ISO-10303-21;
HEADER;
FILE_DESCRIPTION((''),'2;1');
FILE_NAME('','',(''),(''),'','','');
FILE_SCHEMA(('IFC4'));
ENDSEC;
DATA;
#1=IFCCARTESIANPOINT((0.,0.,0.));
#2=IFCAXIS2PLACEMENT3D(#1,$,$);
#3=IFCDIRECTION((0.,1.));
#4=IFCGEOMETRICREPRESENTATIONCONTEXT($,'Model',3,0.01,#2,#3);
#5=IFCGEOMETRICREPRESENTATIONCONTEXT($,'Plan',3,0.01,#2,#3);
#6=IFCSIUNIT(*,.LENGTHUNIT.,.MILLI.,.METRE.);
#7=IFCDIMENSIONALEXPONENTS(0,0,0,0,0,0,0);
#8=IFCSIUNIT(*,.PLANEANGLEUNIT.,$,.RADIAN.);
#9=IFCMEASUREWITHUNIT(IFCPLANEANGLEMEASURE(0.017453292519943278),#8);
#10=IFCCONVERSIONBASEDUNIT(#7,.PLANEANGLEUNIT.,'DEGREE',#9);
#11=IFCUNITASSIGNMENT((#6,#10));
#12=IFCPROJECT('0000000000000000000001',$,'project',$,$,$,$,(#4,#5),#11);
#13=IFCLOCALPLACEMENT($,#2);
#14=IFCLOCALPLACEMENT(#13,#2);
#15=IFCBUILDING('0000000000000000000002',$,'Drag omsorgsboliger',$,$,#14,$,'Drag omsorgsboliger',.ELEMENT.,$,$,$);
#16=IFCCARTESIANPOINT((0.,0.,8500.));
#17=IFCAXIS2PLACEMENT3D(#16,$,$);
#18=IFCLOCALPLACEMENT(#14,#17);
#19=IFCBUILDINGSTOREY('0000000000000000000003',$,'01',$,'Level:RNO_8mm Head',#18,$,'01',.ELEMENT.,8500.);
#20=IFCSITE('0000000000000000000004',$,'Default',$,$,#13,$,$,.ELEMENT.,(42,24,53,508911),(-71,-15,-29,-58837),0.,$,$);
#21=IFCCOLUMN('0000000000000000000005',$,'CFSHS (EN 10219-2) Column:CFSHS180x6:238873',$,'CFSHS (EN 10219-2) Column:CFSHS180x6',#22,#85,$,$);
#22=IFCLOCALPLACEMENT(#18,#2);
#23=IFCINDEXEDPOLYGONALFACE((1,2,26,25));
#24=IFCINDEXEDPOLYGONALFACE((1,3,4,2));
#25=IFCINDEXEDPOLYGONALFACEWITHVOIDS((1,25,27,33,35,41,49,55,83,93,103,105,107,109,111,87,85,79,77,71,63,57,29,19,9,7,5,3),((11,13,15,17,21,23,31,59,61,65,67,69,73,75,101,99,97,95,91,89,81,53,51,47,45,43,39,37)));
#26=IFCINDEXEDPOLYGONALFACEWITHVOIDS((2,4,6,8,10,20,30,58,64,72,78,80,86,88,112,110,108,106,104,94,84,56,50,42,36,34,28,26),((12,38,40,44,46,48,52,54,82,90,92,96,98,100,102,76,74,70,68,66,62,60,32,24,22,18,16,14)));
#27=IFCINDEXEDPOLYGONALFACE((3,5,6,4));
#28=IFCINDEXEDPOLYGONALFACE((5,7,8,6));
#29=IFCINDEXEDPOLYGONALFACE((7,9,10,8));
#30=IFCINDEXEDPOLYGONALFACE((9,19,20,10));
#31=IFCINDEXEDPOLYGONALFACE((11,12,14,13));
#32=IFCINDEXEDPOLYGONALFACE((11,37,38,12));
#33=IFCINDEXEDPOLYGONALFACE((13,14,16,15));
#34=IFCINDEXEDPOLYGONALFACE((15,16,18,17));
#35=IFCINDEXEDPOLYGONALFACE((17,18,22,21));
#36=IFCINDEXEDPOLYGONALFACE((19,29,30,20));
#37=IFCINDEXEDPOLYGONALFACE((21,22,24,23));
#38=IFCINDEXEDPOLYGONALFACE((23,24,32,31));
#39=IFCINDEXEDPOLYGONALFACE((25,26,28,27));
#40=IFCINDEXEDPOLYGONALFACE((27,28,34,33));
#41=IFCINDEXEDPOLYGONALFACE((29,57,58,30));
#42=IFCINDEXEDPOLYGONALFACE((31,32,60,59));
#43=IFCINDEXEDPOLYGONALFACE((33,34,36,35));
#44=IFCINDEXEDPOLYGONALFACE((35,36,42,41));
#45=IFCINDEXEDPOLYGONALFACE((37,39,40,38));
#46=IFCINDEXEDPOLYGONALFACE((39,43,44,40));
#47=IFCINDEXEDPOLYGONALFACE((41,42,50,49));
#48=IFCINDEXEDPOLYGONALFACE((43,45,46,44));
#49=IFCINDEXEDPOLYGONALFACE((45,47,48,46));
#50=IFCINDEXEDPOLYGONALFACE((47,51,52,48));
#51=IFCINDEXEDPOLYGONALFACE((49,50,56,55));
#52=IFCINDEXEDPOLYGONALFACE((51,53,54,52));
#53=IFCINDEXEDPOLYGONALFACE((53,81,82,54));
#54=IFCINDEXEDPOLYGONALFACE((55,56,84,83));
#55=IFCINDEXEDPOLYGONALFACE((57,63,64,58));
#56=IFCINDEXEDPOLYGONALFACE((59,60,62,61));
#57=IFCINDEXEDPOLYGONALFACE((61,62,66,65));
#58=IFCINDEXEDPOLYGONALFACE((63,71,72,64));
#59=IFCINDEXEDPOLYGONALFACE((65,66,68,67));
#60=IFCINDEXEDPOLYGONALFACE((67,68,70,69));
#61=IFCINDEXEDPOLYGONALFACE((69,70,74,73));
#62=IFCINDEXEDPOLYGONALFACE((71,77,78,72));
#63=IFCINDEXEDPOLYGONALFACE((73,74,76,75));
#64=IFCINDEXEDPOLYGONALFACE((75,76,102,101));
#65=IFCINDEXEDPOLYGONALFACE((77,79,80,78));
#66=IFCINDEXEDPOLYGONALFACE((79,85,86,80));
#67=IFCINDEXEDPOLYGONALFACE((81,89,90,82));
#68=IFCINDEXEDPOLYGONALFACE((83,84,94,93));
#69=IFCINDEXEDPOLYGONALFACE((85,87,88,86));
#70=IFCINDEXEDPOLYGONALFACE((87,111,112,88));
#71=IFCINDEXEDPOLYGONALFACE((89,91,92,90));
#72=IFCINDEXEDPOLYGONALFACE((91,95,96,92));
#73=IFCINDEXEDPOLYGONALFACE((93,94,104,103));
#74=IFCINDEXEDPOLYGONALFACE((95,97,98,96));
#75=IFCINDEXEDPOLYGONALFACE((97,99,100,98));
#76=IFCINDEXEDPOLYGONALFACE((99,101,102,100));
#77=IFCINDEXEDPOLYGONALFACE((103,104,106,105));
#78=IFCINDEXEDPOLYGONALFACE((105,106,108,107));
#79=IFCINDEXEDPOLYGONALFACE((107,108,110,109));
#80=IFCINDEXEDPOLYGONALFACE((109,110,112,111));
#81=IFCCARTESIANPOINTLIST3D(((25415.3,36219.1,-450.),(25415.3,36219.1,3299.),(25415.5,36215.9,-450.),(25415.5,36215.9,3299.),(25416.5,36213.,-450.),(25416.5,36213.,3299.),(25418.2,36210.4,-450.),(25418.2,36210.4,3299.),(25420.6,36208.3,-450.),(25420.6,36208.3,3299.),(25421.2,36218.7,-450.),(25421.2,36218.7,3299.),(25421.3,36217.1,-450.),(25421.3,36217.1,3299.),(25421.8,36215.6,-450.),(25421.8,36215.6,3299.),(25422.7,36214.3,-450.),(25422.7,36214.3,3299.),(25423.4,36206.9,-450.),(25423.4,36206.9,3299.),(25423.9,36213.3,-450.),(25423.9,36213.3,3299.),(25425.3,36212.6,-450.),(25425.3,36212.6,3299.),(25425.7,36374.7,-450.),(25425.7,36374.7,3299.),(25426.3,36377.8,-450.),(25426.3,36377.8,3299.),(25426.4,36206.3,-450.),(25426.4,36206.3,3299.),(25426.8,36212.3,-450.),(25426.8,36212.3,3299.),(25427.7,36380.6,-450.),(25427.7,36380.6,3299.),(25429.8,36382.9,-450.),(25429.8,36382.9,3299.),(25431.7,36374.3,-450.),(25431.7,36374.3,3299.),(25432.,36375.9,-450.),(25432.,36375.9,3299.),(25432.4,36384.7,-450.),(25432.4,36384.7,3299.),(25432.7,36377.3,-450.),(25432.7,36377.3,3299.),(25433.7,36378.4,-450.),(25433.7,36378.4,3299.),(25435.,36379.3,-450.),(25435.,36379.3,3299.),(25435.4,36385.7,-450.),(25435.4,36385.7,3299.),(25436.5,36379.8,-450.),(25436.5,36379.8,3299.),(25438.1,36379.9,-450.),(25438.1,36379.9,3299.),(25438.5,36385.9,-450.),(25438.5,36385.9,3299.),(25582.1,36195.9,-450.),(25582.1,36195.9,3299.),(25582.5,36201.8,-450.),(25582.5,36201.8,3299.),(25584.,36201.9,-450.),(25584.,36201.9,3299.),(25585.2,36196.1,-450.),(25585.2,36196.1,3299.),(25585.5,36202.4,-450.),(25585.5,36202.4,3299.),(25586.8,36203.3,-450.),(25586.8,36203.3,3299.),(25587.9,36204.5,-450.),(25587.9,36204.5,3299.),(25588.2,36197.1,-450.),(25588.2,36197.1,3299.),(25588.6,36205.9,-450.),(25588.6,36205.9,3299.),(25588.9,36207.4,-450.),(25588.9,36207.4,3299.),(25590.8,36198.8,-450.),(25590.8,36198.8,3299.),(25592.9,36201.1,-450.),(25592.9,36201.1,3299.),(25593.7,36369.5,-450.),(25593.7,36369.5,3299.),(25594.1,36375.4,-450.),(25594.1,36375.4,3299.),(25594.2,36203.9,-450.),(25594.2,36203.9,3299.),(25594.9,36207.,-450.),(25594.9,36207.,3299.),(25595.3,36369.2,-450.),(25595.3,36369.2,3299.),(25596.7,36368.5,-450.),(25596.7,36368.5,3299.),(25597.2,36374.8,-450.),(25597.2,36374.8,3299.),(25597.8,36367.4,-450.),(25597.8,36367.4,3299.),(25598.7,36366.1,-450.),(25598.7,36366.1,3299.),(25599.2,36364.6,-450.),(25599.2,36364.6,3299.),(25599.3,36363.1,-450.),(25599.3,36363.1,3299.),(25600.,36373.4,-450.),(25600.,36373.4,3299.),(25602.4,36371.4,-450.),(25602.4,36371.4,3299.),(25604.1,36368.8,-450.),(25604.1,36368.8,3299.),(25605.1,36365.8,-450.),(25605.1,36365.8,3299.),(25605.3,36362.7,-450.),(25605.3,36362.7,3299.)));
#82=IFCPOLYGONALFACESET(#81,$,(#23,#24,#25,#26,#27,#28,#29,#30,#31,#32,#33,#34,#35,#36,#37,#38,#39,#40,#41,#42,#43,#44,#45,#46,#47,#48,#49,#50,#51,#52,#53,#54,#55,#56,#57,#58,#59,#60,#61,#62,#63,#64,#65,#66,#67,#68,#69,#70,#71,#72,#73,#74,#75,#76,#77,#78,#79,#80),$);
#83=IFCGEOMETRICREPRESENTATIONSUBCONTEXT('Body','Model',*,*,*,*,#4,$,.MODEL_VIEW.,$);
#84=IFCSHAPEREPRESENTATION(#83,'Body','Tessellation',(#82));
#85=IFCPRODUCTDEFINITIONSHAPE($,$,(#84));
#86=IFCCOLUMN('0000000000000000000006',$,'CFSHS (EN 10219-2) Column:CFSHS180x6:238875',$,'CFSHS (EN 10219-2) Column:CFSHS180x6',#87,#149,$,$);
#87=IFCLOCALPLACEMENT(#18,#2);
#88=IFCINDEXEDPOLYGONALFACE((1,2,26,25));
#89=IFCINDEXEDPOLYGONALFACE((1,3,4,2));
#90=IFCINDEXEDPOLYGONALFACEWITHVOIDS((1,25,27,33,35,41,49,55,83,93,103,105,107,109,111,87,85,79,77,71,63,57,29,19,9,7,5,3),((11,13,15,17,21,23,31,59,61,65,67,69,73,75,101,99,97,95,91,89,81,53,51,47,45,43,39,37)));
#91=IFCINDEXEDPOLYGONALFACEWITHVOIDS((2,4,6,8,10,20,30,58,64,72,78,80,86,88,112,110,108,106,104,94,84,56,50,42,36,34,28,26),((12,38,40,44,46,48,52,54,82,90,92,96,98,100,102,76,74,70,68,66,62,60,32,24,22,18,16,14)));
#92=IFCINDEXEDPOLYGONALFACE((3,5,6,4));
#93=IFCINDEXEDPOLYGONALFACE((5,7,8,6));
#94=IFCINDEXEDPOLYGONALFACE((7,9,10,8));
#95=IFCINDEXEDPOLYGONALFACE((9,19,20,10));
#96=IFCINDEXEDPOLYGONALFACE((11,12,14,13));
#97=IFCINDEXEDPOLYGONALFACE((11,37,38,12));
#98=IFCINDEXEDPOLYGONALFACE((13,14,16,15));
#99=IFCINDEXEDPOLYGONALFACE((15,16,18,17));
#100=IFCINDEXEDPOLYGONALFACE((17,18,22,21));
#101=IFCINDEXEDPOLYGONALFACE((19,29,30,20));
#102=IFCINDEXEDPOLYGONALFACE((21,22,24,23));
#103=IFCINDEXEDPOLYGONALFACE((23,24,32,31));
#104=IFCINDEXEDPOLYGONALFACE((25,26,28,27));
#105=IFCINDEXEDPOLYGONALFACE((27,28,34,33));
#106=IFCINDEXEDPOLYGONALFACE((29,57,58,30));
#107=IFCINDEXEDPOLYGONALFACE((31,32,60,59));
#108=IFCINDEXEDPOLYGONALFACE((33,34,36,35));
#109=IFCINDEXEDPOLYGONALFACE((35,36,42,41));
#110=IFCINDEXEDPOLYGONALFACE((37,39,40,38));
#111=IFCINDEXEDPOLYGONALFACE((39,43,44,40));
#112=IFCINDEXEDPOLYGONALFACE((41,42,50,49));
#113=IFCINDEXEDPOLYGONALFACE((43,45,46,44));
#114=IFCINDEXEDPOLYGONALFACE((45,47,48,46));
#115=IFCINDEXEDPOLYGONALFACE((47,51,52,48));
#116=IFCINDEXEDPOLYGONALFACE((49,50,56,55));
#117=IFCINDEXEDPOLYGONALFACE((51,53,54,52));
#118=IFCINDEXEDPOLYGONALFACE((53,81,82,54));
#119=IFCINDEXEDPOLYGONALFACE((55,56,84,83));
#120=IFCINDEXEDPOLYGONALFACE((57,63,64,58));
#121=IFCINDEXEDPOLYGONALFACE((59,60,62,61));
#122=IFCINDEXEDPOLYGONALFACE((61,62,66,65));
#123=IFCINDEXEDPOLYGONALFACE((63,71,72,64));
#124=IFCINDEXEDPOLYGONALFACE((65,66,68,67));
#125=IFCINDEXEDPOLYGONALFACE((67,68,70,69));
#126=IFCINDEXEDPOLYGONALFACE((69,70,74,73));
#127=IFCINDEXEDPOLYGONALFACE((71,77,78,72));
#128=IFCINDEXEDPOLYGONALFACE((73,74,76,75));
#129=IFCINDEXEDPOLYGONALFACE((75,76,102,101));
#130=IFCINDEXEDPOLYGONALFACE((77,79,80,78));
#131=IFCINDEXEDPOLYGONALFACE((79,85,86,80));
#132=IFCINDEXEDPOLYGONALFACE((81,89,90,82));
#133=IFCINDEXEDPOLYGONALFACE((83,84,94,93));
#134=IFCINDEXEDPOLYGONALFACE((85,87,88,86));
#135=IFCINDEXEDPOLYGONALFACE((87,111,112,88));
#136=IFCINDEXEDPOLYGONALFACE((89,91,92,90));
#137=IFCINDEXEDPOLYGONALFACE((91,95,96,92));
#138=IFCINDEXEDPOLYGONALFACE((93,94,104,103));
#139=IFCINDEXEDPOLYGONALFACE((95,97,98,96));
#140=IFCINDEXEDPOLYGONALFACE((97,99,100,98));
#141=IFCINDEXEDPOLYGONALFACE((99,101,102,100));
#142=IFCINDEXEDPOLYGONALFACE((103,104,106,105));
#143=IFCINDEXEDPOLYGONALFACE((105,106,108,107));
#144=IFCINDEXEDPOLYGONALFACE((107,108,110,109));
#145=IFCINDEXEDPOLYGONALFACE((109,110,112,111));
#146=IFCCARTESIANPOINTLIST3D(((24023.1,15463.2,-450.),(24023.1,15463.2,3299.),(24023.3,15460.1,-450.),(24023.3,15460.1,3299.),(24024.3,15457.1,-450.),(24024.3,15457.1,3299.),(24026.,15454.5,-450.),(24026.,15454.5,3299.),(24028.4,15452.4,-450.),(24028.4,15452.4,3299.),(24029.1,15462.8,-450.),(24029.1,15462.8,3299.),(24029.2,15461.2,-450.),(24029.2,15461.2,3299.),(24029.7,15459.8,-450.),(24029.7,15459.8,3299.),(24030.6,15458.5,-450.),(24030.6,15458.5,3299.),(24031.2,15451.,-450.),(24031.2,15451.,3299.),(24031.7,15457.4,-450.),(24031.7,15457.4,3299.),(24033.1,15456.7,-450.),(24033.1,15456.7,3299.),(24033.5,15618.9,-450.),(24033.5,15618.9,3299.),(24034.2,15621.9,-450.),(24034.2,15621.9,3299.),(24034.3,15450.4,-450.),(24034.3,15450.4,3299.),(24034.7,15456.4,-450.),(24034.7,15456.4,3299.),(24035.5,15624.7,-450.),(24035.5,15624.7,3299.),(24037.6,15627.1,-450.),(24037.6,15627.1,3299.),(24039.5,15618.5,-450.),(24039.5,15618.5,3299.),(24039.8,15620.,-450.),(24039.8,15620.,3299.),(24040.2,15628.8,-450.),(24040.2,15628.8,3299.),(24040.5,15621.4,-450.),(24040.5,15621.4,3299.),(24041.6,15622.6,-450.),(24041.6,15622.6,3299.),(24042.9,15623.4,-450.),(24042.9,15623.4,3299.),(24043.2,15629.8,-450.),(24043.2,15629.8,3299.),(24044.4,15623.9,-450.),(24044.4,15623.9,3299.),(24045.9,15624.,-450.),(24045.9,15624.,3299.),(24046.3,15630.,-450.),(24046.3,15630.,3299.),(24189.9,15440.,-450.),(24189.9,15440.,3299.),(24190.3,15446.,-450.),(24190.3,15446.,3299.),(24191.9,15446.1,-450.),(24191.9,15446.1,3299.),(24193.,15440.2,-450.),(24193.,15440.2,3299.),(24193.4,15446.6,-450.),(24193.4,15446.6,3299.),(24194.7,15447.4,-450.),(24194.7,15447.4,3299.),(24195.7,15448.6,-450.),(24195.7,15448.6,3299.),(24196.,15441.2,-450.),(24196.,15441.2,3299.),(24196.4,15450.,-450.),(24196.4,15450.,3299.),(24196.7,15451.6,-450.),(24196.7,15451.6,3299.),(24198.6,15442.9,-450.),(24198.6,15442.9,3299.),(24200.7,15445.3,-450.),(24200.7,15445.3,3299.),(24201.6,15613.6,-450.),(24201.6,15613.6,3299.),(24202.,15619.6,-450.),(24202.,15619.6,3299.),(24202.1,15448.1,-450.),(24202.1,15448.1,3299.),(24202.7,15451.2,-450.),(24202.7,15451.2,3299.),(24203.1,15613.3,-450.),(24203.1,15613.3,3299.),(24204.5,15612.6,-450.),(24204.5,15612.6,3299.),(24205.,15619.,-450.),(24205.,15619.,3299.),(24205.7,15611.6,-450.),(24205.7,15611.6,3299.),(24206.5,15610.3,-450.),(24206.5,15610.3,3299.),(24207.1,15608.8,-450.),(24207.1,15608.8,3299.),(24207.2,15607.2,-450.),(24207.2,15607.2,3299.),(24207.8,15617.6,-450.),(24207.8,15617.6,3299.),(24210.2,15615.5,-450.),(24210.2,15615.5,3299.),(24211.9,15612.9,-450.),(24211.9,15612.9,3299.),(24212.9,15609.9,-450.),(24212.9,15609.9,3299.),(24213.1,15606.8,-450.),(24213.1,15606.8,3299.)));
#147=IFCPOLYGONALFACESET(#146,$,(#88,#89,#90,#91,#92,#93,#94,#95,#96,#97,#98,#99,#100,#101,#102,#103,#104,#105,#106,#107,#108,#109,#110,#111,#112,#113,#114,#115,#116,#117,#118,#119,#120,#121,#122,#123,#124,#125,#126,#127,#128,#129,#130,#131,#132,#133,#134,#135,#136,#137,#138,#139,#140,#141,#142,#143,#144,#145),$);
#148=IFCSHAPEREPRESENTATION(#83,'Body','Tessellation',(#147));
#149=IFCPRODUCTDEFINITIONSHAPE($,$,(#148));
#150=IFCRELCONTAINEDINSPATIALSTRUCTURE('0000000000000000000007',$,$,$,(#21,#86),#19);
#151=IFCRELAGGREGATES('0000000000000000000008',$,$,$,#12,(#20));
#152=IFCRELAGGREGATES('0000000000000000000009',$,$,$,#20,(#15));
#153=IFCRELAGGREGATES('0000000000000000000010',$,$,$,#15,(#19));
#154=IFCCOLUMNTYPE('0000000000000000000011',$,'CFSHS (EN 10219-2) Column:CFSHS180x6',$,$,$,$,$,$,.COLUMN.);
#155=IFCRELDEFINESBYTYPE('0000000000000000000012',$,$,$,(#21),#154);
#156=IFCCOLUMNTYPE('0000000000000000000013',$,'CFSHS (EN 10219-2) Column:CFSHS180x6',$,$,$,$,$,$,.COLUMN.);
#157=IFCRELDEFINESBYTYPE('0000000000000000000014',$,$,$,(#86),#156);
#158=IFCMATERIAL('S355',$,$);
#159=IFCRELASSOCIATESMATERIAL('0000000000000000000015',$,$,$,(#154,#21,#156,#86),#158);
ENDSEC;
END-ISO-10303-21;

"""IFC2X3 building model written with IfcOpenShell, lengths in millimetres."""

from ifc_helpers import new_model, entity, si_unit, converted_unit, direction, frame, frame_2d, origin, place, context, subcontext, project, spatial, polyline, circle_curve, parameter, trimmed, segment, composite_curve, outline, extrude, source, transform, mapped, material, type_object, type_shapes, element, save


model = new_model("IFC2X3")

# Units and contexts
model_context = context("Model", 3, precision=0.01, world=origin(), true_north=direction((0.0, 1.0)))
plan_context = context("Plan", 3, precision=0.01, world=origin(), true_north=direction((0.0, 1.0)))
body_context = subcontext(model_context, "Body", "Model", "MODEL_VIEW")
ifc_project = project(units=[si_unit("LENGTHUNIT", "METRE", prefix="MILLI"), converted_unit("PLANEANGLEUNIT", "DEGREE", entity("IfcPlaneAngleMeasure", 0.017453292519943278), si_unit("PLANEANGLEUNIT", "RADIAN"), dimensions=[0, 0, 0, 0, 0, 0, 0])], contexts=[model_context, plan_context])

# Site, building, storey
site_placement = place(None, origin())
site = spatial("IfcSite", under=ifc_project, at=site_placement, Name="Default", CompositionType="ELEMENT", RefLatitude=(42, 24, 53, 508911), RefLongitude=(-71, -15, -29, -58837), RefElevation=0.0)
building_placement = place(site_placement, origin())
building = spatial("IfcBuilding", under=site, at=building_placement, Name="Drag omsorgsboliger", LongName="Drag omsorgsboliger", CompositionType="ELEMENT")
storey_placement = place(building_placement, frame((0.0, 0.0, 8500.0)))
storey = spatial("IfcBuildingStorey", under=building, at=storey_placement, Name="01", ObjectType="Level:RNO_8mm Head", LongName="01", CompositionType="ELEMENT", Elevation=8500.0)

# Columns
ifc_material = material(Name="S355")
column_type_1 = type_object("IfcColumnType", Name="CFSHS (EN 10219-2) Column:CFSHS180x6", PredefinedType="COLUMN", material=ifc_material)
shared_shape_1 = source(origin(), body_context, "Body", "SweptSolid", [
    extrude(outline(composite_curve([segment(polyline([(-78.0, -90.0), (78.0, -90.0)]), True, "CONTINUOUS"), segment(trimmed(circle_curve(frame_2d((78.0, -78.0), x_axis=(-1.0, 0.0)), 12.0), [parameter(90.0)], [parameter(180.0)], True, "PARAMETER"), True, "CONTINUOUS"), segment(polyline([(90.0, -78.0), (90.0, 78.0)]), True, "CONTINUOUS"), segment(trimmed(circle_curve(frame_2d((78.0, 78.0), x_axis=(-1.0, 0.0)), 12.0), [parameter(180.0)], [parameter(270.0)], True, "PARAMETER"), True, "CONTINUOUS"), segment(polyline([(78.0, 90.0), (-78.0, 90.0)]), True, "CONTINUOUS"), segment(trimmed(circle_curve(frame_2d((-78.0, 78.0), x_axis=(-1.0, 0.0)), 12.0), [parameter(270.0)], [parameter(360.0)], True, "PARAMETER"), True, "CONTINUOUS"), segment(polyline([(-90.0, 78.0), (-90.0, -78.0)]), True, "CONTINUOUS"), segment(trimmed(circle_curve(frame_2d((-78.0, -78.0), x_axis=(-1.0, 0.0)), 12.0), [parameter(360.0)], [parameter(90.0)], True, "PARAMETER"), True, "CONTINUOUS")], self_intersect=False), holes=[composite_curve([segment(trimmed(circle_curve(frame_2d((-78.0, -78.0), x_axis=(-1.0, 0.0)), 6.0), [parameter(360.0)], [parameter(90.0)], True, "PARAMETER"), False, "CONTINUOUS"), segment(polyline([(-84.0, -78.0), (-84.0, 78.0)]), True, "CONTINUOUS"), segment(trimmed(circle_curve(frame_2d((-78.0, 78.0), x_axis=(-1.0, 0.0)), 6.0), [parameter(270.0)], [parameter(360.0)], True, "PARAMETER"), False, "CONTINUOUS"), segment(polyline([(-78.0, 84.0), (78.0, 84.0)]), True, "CONTINUOUS"), segment(trimmed(circle_curve(frame_2d((78.0, 78.0), x_axis=(-1.0, 0.0)), 6.0), [parameter(180.0)], [parameter(270.0)], True, "PARAMETER"), False, "CONTINUOUS"), segment(polyline([(84.0, 78.0), (84.0, -78.0)]), True, "CONTINUOUS"), segment(trimmed(circle_curve(frame_2d((78.0, -78.0), x_axis=(-1.0, 0.0)), 6.0), [parameter(90.0)], [parameter(180.0)], True, "PARAMETER"), False, "CONTINUOUS"), segment(polyline([(78.0, -84.0), (-78.0, -84.0)]), True, "CONTINUOUS")], self_intersect=False)]), frame((25510.3, 36290.9, 8050.0), z_axis=(0.0, 0.0, 1.0), x_axis=(-0.997758, 0.066923, 0.0)), (0.0, 0.0, 1.0), 3749.0),
])
type_shapes(column_type_1, [shared_shape_1])
column_1_placement = place(storey_placement, frame((0.0, 0.0, -8500.0)))
element("IfcColumn", 1, at=column_1_placement, inside=storey, type_object=column_type_1, material=ifc_material, Name="CFSHS (EN 10219-2) Column:CFSHS180x6:238873", ObjectType="CFSHS (EN 10219-2) Column:CFSHS180x6", context=body_context, shape_type="MappedRepresentation", body=[
    mapped(shared_shape_1, transform((0.0, 0.0, 0.0), scale=1.0)),
])
column_type_2 = type_object("IfcColumnType", Name="CFSHS (EN 10219-2) Column:CFSHS180x6", PredefinedType="COLUMN", material=ifc_material)
shared_shape_2 = source(origin(), body_context, "Body", "SweptSolid", [
    extrude(outline(composite_curve([segment(polyline([(-78.0, -90.0), (78.0, -90.0)]), True, "CONTINUOUS"), segment(trimmed(circle_curve(frame_2d((78.0, -78.0), x_axis=(-1.0, 0.0)), 12.0), [parameter(90.0)], [parameter(180.0)], True, "PARAMETER"), True, "CONTINUOUS"), segment(polyline([(90.0, -78.0), (90.0, 78.0)]), True, "CONTINUOUS"), segment(trimmed(circle_curve(frame_2d((78.0, 78.0), x_axis=(-1.0, 0.0)), 12.0), [parameter(180.0)], [parameter(270.0)], True, "PARAMETER"), True, "CONTINUOUS"), segment(polyline([(78.0, 90.0), (-78.0, 90.0)]), True, "CONTINUOUS"), segment(trimmed(circle_curve(frame_2d((-78.0, 78.0), x_axis=(-1.0, 0.0)), 12.0), [parameter(270.0)], [parameter(360.0)], True, "PARAMETER"), True, "CONTINUOUS"), segment(polyline([(-90.0, 78.0), (-90.0, -78.0)]), True, "CONTINUOUS"), segment(trimmed(circle_curve(frame_2d((-78.0, -78.0), x_axis=(-1.0, 0.0)), 12.0), [parameter(360.0)], [parameter(90.0)], True, "PARAMETER"), True, "CONTINUOUS")], self_intersect=False), holes=[composite_curve([segment(trimmed(circle_curve(frame_2d((-78.0, -78.0), x_axis=(-1.0, 0.0)), 6.0), [parameter(360.0)], [parameter(90.0)], True, "PARAMETER"), False, "CONTINUOUS"), segment(polyline([(-84.0, -78.0), (-84.0, 78.0)]), True, "CONTINUOUS"), segment(trimmed(circle_curve(frame_2d((-78.0, 78.0), x_axis=(-1.0, 0.0)), 6.0), [parameter(270.0)], [parameter(360.0)], True, "PARAMETER"), False, "CONTINUOUS"), segment(polyline([(-78.0, 84.0), (78.0, 84.0)]), True, "CONTINUOUS"), segment(trimmed(circle_curve(frame_2d((78.0, 78.0), x_axis=(-1.0, 0.0)), 6.0), [parameter(180.0)], [parameter(270.0)], True, "PARAMETER"), False, "CONTINUOUS"), segment(polyline([(84.0, 78.0), (84.0, -78.0)]), True, "CONTINUOUS"), segment(trimmed(circle_curve(frame_2d((78.0, -78.0), x_axis=(-1.0, 0.0)), 6.0), [parameter(90.0)], [parameter(180.0)], True, "PARAMETER"), False, "CONTINUOUS"), segment(polyline([(78.0, -84.0), (-78.0, -84.0)]), True, "CONTINUOUS")], self_intersect=False)]), frame((24118.1, 15535.0, 8050.0), z_axis=(0.0, 0.0, 1.0), x_axis=(-0.997758, 0.066923, 0.0)), (0.0, 0.0, 1.0), 3749.0),
])
type_shapes(column_type_2, [shared_shape_2])
column_2_placement = place(storey_placement, frame((0.0, 0.0, -8500.0)))
element("IfcColumn", 2, at=column_2_placement, inside=storey, type_object=column_type_2, material=ifc_material, Name="CFSHS (EN 10219-2) Column:CFSHS180x6:238875", ObjectType="CFSHS (EN 10219-2) Column:CFSHS180x6", context=body_context, shape_type="MappedRepresentation", body=[
    mapped(shared_shape_2, transform((0.0, 0.0, 0.0), scale=1.0)),
])

save(model, "model.ifc")
